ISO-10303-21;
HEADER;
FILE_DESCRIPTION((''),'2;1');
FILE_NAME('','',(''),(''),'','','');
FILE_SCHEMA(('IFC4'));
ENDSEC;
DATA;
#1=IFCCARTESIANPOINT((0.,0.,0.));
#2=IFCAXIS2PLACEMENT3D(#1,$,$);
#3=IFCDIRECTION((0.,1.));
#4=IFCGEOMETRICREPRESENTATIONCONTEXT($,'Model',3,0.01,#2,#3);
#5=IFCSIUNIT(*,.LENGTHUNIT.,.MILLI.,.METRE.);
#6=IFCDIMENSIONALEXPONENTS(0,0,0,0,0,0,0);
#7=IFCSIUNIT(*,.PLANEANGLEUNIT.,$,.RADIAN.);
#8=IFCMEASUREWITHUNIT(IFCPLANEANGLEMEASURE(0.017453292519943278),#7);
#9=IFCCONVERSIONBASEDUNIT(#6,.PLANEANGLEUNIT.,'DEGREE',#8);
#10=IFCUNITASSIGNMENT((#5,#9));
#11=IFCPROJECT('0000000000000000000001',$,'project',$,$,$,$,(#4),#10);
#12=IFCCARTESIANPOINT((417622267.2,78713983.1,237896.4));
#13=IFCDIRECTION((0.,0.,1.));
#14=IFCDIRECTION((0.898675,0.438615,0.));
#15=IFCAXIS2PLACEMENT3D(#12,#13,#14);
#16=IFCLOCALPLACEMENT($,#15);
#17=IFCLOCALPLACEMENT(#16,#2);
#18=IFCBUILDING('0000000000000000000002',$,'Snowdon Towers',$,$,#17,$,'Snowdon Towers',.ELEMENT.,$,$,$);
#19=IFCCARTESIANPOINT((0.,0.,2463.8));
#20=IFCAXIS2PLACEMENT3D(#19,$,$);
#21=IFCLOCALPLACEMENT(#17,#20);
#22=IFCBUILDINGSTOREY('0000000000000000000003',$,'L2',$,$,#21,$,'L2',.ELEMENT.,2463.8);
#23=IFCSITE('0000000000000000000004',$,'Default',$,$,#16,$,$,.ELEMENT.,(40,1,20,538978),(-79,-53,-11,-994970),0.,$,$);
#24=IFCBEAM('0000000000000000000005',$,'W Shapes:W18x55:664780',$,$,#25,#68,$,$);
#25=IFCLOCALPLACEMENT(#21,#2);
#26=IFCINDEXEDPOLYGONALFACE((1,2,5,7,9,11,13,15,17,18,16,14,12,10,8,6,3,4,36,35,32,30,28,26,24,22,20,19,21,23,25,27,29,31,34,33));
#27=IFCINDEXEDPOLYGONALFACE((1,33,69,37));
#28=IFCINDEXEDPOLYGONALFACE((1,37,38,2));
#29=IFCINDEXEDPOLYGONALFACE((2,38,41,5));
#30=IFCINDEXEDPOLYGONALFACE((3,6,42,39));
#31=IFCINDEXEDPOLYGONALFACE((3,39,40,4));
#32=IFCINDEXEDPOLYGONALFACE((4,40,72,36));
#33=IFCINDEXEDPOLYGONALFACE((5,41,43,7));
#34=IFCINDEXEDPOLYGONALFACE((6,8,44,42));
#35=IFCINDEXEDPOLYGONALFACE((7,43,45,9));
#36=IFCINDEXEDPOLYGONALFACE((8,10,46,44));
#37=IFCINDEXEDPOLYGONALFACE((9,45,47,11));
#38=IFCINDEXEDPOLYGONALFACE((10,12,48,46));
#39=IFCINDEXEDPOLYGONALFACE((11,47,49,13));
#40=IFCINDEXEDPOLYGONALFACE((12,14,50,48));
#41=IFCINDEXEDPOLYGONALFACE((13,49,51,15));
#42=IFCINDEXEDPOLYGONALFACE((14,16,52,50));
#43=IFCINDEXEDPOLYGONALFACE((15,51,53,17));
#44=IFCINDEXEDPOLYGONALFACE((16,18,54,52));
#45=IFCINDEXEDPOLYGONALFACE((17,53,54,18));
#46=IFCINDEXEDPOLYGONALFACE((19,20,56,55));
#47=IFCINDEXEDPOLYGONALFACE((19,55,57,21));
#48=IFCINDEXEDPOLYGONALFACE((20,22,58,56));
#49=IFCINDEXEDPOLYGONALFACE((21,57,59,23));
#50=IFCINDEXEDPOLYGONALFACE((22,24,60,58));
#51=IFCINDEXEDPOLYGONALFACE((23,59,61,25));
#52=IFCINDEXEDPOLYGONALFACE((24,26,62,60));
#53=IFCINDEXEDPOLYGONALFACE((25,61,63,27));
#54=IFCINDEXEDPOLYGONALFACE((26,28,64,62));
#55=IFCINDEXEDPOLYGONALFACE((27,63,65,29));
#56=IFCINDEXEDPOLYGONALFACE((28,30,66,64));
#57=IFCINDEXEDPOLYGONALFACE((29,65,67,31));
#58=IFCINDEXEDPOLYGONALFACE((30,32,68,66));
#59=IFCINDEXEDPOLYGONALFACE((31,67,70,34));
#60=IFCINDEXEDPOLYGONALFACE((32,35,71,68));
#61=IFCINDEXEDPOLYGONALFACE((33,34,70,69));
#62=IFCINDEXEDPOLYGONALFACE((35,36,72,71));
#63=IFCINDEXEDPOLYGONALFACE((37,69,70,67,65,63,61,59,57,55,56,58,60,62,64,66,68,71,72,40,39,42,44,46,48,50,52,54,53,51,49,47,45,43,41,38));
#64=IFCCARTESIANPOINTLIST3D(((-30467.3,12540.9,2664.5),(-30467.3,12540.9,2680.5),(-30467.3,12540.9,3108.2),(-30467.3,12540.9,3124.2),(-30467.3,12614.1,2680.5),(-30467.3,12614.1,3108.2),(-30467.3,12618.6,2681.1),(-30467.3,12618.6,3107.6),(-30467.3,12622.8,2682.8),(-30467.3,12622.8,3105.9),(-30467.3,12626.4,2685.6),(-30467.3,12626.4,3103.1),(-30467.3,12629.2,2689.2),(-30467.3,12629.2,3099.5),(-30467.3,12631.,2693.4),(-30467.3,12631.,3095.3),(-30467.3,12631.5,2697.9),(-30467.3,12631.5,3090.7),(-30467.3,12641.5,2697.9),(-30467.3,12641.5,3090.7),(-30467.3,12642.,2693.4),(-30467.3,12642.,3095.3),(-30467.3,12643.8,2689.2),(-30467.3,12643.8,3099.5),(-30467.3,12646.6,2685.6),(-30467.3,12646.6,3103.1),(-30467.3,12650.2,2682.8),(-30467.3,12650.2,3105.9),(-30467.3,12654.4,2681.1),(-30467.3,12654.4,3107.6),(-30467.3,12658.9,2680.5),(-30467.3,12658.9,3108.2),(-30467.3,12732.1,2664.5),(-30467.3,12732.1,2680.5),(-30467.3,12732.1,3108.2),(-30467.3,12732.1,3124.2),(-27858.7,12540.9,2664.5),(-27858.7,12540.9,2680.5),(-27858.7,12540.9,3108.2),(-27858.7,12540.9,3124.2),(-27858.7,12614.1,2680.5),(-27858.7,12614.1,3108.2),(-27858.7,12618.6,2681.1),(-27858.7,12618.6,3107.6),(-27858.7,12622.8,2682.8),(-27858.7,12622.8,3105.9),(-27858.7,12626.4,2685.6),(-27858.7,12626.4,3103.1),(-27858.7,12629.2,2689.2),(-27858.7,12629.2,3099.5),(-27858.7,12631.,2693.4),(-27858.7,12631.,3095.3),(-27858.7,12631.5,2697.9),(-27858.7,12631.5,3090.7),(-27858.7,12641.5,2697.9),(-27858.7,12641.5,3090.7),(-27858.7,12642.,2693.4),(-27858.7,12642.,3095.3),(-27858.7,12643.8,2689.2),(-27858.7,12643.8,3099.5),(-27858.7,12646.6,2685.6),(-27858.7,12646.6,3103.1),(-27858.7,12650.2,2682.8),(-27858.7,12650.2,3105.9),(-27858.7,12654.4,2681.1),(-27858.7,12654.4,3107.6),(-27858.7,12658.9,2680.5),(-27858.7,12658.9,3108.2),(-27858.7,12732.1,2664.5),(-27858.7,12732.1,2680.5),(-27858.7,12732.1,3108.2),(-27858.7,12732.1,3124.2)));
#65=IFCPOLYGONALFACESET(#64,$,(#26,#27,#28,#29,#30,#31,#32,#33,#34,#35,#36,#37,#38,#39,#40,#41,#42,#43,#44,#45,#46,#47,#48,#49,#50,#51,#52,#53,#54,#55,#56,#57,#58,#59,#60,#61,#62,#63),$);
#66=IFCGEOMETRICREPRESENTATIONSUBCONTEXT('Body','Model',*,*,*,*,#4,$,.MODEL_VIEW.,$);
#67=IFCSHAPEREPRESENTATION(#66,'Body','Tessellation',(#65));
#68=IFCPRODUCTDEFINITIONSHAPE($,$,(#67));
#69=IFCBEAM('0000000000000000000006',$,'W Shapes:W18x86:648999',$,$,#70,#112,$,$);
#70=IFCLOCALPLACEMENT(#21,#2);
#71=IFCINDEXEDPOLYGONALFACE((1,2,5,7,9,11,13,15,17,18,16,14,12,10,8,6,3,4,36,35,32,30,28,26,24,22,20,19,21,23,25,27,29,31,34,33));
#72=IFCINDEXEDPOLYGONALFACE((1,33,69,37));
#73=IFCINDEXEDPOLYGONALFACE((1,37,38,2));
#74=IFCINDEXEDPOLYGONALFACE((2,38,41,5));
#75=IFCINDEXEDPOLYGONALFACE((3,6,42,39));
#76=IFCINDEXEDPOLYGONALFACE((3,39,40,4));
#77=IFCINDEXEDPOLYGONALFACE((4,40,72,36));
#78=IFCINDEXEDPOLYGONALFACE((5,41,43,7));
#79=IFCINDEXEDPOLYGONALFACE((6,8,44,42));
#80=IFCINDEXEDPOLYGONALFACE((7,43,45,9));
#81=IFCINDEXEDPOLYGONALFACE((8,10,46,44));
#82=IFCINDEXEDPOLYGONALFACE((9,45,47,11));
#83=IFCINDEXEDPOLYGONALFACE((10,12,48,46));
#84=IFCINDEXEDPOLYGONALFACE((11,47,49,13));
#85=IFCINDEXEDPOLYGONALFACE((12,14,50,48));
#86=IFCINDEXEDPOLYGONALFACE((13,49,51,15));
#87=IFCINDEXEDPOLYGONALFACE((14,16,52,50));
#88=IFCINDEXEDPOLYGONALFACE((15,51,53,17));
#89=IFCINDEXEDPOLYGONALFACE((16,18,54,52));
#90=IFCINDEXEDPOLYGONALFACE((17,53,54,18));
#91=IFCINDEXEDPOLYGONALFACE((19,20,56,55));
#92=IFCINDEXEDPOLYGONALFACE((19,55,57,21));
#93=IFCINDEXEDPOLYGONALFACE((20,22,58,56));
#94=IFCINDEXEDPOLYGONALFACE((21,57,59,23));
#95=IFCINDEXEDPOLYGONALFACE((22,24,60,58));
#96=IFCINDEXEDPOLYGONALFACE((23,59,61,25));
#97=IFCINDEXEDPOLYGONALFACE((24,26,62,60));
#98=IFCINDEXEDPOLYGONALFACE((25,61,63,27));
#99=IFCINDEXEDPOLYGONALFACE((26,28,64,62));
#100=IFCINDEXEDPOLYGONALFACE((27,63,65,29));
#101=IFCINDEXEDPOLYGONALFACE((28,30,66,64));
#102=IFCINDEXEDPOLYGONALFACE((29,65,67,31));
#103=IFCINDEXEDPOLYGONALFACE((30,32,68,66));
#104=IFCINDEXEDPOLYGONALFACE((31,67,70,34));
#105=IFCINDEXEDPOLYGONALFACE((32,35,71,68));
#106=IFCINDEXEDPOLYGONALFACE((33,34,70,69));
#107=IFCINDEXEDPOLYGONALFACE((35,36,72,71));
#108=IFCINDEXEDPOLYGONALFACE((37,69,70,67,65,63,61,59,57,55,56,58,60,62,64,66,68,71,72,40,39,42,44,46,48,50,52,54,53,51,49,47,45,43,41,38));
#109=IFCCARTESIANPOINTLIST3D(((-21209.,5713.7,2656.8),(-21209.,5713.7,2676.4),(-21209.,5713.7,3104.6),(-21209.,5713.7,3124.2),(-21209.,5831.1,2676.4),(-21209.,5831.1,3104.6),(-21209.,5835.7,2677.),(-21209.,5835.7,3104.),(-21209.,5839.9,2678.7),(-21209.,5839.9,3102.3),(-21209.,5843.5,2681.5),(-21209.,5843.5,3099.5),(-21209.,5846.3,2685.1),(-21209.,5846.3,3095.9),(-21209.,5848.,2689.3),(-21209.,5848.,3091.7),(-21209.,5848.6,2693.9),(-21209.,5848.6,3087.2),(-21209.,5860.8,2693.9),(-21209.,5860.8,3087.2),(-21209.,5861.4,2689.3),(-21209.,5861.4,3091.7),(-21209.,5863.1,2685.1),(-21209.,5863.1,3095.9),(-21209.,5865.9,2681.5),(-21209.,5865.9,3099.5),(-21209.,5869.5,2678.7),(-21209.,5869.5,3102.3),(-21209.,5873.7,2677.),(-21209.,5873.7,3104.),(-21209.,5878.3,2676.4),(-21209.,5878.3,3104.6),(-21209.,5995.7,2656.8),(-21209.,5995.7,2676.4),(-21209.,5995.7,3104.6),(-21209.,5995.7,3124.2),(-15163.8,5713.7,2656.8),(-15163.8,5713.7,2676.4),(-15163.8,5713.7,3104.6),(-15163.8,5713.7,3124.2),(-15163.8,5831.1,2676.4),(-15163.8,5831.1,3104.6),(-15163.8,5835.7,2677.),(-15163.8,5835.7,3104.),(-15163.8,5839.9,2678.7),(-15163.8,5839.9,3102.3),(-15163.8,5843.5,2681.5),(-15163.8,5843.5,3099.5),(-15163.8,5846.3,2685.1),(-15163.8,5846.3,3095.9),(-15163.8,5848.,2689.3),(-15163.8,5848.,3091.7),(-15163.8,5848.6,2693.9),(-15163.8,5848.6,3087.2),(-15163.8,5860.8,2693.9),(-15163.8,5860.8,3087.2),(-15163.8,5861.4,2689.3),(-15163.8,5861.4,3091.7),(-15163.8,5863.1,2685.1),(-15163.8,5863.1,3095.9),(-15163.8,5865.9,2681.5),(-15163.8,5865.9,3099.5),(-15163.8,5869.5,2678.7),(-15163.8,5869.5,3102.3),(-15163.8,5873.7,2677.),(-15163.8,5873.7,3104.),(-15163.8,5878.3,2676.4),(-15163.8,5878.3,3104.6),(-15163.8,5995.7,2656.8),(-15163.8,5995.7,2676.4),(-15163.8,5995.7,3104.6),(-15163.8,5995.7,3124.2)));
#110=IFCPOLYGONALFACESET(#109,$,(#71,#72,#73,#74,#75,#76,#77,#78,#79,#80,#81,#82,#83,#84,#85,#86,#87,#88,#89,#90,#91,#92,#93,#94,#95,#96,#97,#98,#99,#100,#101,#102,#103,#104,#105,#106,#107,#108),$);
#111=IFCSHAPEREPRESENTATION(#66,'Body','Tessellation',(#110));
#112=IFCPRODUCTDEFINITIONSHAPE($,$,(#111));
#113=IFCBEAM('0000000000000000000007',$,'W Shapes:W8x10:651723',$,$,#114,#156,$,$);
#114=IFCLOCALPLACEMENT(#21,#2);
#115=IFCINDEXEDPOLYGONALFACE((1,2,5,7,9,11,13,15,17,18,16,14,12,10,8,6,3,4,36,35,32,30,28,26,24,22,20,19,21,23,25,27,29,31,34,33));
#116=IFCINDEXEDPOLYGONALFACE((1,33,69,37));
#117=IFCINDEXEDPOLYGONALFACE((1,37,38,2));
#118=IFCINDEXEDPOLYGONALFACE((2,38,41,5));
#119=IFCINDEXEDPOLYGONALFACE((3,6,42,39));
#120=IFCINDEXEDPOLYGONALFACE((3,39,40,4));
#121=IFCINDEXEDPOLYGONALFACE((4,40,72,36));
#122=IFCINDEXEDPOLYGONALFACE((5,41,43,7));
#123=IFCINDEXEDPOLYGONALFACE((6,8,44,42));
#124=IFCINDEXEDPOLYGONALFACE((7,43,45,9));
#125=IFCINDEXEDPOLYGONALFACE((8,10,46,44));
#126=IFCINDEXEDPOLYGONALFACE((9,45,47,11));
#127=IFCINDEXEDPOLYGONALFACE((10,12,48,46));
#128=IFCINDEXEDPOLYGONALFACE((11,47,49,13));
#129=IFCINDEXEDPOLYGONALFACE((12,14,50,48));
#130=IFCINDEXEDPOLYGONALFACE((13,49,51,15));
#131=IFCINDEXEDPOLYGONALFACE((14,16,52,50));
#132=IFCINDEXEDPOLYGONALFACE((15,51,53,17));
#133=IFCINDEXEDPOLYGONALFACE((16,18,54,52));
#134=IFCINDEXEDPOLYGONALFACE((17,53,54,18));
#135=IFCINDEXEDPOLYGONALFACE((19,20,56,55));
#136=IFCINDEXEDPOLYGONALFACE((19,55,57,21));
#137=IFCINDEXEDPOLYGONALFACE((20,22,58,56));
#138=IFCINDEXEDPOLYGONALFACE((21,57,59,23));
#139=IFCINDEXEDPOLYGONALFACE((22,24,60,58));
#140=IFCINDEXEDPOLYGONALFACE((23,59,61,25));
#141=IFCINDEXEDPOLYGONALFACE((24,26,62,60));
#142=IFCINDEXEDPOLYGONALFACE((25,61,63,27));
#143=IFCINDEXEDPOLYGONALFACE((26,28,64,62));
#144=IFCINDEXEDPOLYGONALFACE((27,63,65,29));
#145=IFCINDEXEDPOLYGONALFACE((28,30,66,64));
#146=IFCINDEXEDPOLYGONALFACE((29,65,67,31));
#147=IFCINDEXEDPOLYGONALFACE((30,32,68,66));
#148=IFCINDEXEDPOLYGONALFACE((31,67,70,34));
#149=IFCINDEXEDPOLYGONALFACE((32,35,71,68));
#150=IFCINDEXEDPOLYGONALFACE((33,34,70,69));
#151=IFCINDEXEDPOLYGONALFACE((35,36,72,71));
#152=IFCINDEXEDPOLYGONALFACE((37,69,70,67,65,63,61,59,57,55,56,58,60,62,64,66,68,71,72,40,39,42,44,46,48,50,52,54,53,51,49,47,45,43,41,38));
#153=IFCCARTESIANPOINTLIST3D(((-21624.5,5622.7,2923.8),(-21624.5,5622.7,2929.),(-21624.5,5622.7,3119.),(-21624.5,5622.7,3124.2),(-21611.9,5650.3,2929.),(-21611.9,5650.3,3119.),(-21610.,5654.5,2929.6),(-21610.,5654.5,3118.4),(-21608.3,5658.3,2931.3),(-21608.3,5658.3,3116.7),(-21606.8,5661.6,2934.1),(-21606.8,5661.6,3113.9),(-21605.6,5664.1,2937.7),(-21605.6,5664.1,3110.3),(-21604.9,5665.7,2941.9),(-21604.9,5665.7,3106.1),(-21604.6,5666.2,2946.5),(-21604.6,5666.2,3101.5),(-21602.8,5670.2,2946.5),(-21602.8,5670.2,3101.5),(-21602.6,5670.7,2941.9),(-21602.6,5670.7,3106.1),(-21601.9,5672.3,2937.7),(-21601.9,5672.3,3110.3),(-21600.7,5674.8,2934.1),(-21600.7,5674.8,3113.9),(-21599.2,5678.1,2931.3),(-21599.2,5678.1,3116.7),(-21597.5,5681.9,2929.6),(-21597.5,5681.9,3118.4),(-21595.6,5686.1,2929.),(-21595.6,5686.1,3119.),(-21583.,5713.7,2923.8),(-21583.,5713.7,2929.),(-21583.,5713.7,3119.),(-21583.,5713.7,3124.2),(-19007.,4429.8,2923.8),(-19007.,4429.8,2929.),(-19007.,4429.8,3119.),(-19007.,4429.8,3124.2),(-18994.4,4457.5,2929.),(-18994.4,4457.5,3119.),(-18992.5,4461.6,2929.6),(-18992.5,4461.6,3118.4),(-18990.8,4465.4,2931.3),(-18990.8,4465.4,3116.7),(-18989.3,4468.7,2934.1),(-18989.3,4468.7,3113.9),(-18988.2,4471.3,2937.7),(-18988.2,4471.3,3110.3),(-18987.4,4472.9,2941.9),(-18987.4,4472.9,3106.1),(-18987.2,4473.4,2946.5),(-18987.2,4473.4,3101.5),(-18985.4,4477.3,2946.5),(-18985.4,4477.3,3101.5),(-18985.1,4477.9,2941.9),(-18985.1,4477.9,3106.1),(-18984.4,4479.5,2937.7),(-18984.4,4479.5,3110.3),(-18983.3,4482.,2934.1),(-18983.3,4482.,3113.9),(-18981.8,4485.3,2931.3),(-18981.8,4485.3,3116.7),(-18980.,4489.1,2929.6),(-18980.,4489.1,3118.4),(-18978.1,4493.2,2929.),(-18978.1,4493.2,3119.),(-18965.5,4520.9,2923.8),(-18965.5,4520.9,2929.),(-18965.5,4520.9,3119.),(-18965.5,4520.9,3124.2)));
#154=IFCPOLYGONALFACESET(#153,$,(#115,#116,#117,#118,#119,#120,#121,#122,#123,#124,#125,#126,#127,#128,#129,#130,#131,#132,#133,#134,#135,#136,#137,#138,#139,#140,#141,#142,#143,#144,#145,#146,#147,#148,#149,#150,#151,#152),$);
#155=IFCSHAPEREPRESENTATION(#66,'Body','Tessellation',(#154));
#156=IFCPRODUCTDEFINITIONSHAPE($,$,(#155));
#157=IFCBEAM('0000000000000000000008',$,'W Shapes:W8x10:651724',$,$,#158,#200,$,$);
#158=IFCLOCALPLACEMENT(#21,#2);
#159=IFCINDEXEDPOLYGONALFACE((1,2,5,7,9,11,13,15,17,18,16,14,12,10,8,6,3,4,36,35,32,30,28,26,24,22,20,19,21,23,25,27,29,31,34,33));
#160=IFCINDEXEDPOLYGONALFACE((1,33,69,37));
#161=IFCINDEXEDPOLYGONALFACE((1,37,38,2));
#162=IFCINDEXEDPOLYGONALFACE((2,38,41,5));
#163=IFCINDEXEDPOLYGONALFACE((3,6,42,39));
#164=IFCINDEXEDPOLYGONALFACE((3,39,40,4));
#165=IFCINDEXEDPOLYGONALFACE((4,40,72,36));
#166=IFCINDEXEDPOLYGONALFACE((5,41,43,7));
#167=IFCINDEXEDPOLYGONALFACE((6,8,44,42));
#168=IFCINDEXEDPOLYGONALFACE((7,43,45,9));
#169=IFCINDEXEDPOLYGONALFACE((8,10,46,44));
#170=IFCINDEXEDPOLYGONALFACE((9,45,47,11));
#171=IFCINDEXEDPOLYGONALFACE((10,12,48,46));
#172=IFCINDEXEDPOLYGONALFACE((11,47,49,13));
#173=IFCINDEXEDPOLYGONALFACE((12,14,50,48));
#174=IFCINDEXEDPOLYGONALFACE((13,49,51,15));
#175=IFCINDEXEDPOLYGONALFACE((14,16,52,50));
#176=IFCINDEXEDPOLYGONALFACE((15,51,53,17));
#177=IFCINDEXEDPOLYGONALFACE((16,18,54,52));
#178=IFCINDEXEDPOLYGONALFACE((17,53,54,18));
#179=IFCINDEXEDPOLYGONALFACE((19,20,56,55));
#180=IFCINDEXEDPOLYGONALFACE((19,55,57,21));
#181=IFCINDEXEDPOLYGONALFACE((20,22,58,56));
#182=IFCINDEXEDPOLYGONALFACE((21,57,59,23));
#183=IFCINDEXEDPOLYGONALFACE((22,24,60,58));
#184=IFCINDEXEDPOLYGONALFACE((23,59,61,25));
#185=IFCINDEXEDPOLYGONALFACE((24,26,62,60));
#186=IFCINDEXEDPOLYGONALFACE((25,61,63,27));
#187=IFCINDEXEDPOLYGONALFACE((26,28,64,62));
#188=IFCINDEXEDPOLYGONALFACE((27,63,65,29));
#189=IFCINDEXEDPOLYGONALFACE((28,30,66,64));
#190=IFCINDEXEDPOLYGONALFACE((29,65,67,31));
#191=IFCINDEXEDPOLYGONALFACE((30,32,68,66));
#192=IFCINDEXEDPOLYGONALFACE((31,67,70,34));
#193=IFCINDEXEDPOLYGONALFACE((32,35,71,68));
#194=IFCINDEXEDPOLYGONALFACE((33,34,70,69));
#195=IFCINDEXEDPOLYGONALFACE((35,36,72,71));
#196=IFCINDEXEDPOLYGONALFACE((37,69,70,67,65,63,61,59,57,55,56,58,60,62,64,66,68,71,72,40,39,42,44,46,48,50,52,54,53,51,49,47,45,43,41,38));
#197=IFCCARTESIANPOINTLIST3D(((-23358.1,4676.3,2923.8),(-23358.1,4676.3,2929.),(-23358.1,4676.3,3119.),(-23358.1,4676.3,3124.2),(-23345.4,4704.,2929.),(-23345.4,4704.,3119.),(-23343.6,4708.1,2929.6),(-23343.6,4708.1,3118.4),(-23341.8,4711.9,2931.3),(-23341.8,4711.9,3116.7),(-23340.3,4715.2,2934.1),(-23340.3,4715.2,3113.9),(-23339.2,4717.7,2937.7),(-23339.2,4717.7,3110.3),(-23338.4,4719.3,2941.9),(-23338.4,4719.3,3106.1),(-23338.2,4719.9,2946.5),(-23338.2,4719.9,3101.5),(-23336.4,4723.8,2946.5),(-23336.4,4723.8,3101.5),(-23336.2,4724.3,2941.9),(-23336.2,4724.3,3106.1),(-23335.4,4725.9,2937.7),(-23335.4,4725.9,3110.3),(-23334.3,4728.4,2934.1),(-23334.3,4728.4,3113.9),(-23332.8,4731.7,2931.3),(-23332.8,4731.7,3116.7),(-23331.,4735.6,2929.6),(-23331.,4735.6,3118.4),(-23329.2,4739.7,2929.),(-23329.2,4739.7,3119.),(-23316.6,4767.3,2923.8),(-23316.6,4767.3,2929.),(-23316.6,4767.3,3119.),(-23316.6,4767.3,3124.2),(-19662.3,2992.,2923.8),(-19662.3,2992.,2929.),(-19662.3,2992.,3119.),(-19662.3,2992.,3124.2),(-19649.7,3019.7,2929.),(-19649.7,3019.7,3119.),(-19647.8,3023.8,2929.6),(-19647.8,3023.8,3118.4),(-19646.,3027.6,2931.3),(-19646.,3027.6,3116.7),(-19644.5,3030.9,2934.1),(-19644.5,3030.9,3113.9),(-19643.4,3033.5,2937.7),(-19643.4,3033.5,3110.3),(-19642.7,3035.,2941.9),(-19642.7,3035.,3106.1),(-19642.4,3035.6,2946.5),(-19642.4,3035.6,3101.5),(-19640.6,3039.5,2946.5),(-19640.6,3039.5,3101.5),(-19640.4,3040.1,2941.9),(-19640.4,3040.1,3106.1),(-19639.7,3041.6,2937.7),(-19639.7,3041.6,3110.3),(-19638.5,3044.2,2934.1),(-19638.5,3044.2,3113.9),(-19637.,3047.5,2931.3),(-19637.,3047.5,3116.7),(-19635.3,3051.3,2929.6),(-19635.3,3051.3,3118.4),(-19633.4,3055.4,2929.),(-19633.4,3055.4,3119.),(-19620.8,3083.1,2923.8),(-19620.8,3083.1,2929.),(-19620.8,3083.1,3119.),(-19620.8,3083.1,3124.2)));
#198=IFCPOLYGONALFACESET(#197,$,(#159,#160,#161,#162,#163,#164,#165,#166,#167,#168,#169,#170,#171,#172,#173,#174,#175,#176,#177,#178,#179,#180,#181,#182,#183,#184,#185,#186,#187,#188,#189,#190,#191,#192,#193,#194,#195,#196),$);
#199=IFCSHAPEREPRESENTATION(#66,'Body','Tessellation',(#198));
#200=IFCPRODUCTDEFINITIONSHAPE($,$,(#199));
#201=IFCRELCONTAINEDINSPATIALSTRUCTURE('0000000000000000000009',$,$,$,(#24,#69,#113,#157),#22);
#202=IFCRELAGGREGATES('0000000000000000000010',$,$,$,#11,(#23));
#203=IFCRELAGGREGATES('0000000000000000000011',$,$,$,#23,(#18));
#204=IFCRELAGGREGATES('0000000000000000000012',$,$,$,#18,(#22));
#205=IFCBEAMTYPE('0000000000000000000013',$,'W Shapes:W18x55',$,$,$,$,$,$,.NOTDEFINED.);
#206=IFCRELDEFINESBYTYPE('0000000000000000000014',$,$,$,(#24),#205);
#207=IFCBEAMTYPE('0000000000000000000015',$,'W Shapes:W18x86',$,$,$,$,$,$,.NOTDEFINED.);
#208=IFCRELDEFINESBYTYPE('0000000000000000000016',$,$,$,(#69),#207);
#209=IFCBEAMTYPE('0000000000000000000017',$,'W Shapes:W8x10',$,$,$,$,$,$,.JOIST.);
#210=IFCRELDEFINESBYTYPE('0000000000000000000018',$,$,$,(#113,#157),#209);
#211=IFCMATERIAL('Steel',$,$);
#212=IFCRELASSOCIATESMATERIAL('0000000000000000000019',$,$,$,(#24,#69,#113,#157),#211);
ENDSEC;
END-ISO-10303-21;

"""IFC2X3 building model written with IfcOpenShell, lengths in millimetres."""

from ifc_helpers import new_model, entity, si_unit, converted_unit, direction, frame, frame_2d, origin, place, context, subcontext, project, spatial, i_section, extrude, material, type_object, element, save


model = new_model("IFC2X3")

# Units and contexts
model_context = context("Model", 3, precision=0.01, world=origin(), true_north=direction((0.0, 1.0)))
body_context = subcontext(model_context, "Body", "Model", "MODEL_VIEW")
ifc_project = project(units=[si_unit("LENGTHUNIT", "METRE", prefix="MILLI"), converted_unit("PLANEANGLEUNIT", "DEGREE", entity("IfcPlaneAngleMeasure", 0.017453292519943278), si_unit("PLANEANGLEUNIT", "RADIAN"), dimensions=[0, 0, 0, 0, 0, 0, 0])], contexts=[model_context])

# Site, building, storey
site_placement = place(None, frame((417622267.2, 78713983.1, 237896.4), z_axis=(0.0, 0.0, 1.0), x_axis=(0.898675, 0.438615, 0.0)))
site = spatial("IfcSite", under=ifc_project, at=site_placement, Name="Default", CompositionType="ELEMENT", RefLatitude=(40, 1, 20, 538978), RefLongitude=(-79, -53, -11, -994970), RefElevation=0.0)
building_placement = place(site_placement, origin())
building = spatial("IfcBuilding", under=site, at=building_placement, Name="Snowdon Towers", LongName="Snowdon Towers", CompositionType="ELEMENT")
storey_placement = place(building_placement, frame((0.0, 0.0, 2463.8)))
storey = spatial("IfcBuildingStorey", under=building, at=storey_placement, Name="L2", LongName="L2", CompositionType="ELEMENT", Elevation=2463.8)

# Beams
ifc_material_1 = material(Name="Steel")
beam_type_1 = type_object("IfcBeamType", Name="W Shapes:W18x55", PredefinedType="NOTDEFINED")
beam_1_placement = place(storey_placement, frame((-30467.3, 12636.5, 3124.2)))
element("IfcBeam", 1, at=beam_1_placement, inside=storey, type_object=beam_type_1, material=ifc_material_1, Name="W Shapes:W18x55:664780", context=body_context, shape_type="SweptSolid", body=[
    extrude(i_section(OverallWidth=191.3, OverallDepth=459.7, WebThickness=9.9, FlangeThickness=16.0, FilletRadius=17.5, at=frame_2d((0.0, 0.0), x_axis=(0.0, 1.0))), frame((0.0, 0.0, -229.9), z_axis=(1.0, 0.0, 0.0), x_axis=(0.0, 0.0, -1.0)), (0.0, 0.0, 1.0), 2608.6),
])
beam_type_2 = type_object("IfcBeamType", Name="W Shapes:W18x86", PredefinedType="NOTDEFINED")
beam_2_placement = place(storey_placement, frame((-21336.0, 5854.7, 3124.2)))
element("IfcBeam", 2, at=beam_2_placement, inside=storey, type_object=beam_type_2, material=ifc_material_1, Name="W Shapes:W18x86:648999", context=body_context, shape_type="SweptSolid", body=[
    extrude(i_section(OverallWidth=281.9, OverallDepth=467.4, WebThickness=12.2, FlangeThickness=19.6, FilletRadius=17.5, at=frame_2d((0.0, 0.0), x_axis=(0.0, 1.0))), frame((127.0, 0.0, -233.7), z_axis=(1.0, 0.0, 0.0), x_axis=(0.0, 0.0, -1.0)), (0.0, 0.0, 1.0), 6045.2),
])
beam_type_3 = type_object("IfcBeamType", Name="W Shapes:W8x10", PredefinedType="JOIST")
beam_3_placement = place(storey_placement, frame((-22013.0, 5854.7, 3124.2), z_axis=(0.0, 0.0, 1.0), x_axis=(0.909961, -0.414693, 0.0)))
element("IfcBeam", 3, at=beam_3_placement, inside=storey, type_object=beam_type_3, material=ifc_material_1, Name="W Shapes:W8x10:651723", context=body_context, shape_type="SweptSolid", body=[
    extrude(i_section(OverallWidth=100.1, OverallDepth=200.4, WebThickness=4.3, FlangeThickness=5.2, FilletRadius=17.5, at=frame_2d((0.0, 0.0), x_axis=(0.0, 1.0))), frame((449.7, 0.0, -100.2), z_axis=(1.0, 0.0, 0.0), x_axis=(0.0, 0.0, -1.0)), (0.0, 0.0, 1.0), 2876.4),
])
beam_4_placement = place(storey_placement, frame((-23465.6, 4780.3, 3124.2), z_axis=(0.0, 0.0, 1.0), x_axis=(0.909961, -0.414693, 0.0)))
element("IfcBeam", 4, at=beam_4_placement, inside=storey, type_object=beam_type_3, material=ifc_material_1, Name="W Shapes:W8x10:651724", context=body_context, shape_type="SweptSolid", body=[
    extrude(i_section(OverallWidth=100.1, OverallDepth=200.4, WebThickness=4.3, FlangeThickness=5.2, FilletRadius=17.5, at=frame_2d((0.0, 0.0), x_axis=(0.0, 1.0))), frame((141.0, 0.0, -100.2), z_axis=(1.0, 0.0, 0.0), x_axis=(0.0, 0.0, -1.0)), (0.0, 0.0, 1.0), 4061.5),
])

save(model, "model.ifc")
